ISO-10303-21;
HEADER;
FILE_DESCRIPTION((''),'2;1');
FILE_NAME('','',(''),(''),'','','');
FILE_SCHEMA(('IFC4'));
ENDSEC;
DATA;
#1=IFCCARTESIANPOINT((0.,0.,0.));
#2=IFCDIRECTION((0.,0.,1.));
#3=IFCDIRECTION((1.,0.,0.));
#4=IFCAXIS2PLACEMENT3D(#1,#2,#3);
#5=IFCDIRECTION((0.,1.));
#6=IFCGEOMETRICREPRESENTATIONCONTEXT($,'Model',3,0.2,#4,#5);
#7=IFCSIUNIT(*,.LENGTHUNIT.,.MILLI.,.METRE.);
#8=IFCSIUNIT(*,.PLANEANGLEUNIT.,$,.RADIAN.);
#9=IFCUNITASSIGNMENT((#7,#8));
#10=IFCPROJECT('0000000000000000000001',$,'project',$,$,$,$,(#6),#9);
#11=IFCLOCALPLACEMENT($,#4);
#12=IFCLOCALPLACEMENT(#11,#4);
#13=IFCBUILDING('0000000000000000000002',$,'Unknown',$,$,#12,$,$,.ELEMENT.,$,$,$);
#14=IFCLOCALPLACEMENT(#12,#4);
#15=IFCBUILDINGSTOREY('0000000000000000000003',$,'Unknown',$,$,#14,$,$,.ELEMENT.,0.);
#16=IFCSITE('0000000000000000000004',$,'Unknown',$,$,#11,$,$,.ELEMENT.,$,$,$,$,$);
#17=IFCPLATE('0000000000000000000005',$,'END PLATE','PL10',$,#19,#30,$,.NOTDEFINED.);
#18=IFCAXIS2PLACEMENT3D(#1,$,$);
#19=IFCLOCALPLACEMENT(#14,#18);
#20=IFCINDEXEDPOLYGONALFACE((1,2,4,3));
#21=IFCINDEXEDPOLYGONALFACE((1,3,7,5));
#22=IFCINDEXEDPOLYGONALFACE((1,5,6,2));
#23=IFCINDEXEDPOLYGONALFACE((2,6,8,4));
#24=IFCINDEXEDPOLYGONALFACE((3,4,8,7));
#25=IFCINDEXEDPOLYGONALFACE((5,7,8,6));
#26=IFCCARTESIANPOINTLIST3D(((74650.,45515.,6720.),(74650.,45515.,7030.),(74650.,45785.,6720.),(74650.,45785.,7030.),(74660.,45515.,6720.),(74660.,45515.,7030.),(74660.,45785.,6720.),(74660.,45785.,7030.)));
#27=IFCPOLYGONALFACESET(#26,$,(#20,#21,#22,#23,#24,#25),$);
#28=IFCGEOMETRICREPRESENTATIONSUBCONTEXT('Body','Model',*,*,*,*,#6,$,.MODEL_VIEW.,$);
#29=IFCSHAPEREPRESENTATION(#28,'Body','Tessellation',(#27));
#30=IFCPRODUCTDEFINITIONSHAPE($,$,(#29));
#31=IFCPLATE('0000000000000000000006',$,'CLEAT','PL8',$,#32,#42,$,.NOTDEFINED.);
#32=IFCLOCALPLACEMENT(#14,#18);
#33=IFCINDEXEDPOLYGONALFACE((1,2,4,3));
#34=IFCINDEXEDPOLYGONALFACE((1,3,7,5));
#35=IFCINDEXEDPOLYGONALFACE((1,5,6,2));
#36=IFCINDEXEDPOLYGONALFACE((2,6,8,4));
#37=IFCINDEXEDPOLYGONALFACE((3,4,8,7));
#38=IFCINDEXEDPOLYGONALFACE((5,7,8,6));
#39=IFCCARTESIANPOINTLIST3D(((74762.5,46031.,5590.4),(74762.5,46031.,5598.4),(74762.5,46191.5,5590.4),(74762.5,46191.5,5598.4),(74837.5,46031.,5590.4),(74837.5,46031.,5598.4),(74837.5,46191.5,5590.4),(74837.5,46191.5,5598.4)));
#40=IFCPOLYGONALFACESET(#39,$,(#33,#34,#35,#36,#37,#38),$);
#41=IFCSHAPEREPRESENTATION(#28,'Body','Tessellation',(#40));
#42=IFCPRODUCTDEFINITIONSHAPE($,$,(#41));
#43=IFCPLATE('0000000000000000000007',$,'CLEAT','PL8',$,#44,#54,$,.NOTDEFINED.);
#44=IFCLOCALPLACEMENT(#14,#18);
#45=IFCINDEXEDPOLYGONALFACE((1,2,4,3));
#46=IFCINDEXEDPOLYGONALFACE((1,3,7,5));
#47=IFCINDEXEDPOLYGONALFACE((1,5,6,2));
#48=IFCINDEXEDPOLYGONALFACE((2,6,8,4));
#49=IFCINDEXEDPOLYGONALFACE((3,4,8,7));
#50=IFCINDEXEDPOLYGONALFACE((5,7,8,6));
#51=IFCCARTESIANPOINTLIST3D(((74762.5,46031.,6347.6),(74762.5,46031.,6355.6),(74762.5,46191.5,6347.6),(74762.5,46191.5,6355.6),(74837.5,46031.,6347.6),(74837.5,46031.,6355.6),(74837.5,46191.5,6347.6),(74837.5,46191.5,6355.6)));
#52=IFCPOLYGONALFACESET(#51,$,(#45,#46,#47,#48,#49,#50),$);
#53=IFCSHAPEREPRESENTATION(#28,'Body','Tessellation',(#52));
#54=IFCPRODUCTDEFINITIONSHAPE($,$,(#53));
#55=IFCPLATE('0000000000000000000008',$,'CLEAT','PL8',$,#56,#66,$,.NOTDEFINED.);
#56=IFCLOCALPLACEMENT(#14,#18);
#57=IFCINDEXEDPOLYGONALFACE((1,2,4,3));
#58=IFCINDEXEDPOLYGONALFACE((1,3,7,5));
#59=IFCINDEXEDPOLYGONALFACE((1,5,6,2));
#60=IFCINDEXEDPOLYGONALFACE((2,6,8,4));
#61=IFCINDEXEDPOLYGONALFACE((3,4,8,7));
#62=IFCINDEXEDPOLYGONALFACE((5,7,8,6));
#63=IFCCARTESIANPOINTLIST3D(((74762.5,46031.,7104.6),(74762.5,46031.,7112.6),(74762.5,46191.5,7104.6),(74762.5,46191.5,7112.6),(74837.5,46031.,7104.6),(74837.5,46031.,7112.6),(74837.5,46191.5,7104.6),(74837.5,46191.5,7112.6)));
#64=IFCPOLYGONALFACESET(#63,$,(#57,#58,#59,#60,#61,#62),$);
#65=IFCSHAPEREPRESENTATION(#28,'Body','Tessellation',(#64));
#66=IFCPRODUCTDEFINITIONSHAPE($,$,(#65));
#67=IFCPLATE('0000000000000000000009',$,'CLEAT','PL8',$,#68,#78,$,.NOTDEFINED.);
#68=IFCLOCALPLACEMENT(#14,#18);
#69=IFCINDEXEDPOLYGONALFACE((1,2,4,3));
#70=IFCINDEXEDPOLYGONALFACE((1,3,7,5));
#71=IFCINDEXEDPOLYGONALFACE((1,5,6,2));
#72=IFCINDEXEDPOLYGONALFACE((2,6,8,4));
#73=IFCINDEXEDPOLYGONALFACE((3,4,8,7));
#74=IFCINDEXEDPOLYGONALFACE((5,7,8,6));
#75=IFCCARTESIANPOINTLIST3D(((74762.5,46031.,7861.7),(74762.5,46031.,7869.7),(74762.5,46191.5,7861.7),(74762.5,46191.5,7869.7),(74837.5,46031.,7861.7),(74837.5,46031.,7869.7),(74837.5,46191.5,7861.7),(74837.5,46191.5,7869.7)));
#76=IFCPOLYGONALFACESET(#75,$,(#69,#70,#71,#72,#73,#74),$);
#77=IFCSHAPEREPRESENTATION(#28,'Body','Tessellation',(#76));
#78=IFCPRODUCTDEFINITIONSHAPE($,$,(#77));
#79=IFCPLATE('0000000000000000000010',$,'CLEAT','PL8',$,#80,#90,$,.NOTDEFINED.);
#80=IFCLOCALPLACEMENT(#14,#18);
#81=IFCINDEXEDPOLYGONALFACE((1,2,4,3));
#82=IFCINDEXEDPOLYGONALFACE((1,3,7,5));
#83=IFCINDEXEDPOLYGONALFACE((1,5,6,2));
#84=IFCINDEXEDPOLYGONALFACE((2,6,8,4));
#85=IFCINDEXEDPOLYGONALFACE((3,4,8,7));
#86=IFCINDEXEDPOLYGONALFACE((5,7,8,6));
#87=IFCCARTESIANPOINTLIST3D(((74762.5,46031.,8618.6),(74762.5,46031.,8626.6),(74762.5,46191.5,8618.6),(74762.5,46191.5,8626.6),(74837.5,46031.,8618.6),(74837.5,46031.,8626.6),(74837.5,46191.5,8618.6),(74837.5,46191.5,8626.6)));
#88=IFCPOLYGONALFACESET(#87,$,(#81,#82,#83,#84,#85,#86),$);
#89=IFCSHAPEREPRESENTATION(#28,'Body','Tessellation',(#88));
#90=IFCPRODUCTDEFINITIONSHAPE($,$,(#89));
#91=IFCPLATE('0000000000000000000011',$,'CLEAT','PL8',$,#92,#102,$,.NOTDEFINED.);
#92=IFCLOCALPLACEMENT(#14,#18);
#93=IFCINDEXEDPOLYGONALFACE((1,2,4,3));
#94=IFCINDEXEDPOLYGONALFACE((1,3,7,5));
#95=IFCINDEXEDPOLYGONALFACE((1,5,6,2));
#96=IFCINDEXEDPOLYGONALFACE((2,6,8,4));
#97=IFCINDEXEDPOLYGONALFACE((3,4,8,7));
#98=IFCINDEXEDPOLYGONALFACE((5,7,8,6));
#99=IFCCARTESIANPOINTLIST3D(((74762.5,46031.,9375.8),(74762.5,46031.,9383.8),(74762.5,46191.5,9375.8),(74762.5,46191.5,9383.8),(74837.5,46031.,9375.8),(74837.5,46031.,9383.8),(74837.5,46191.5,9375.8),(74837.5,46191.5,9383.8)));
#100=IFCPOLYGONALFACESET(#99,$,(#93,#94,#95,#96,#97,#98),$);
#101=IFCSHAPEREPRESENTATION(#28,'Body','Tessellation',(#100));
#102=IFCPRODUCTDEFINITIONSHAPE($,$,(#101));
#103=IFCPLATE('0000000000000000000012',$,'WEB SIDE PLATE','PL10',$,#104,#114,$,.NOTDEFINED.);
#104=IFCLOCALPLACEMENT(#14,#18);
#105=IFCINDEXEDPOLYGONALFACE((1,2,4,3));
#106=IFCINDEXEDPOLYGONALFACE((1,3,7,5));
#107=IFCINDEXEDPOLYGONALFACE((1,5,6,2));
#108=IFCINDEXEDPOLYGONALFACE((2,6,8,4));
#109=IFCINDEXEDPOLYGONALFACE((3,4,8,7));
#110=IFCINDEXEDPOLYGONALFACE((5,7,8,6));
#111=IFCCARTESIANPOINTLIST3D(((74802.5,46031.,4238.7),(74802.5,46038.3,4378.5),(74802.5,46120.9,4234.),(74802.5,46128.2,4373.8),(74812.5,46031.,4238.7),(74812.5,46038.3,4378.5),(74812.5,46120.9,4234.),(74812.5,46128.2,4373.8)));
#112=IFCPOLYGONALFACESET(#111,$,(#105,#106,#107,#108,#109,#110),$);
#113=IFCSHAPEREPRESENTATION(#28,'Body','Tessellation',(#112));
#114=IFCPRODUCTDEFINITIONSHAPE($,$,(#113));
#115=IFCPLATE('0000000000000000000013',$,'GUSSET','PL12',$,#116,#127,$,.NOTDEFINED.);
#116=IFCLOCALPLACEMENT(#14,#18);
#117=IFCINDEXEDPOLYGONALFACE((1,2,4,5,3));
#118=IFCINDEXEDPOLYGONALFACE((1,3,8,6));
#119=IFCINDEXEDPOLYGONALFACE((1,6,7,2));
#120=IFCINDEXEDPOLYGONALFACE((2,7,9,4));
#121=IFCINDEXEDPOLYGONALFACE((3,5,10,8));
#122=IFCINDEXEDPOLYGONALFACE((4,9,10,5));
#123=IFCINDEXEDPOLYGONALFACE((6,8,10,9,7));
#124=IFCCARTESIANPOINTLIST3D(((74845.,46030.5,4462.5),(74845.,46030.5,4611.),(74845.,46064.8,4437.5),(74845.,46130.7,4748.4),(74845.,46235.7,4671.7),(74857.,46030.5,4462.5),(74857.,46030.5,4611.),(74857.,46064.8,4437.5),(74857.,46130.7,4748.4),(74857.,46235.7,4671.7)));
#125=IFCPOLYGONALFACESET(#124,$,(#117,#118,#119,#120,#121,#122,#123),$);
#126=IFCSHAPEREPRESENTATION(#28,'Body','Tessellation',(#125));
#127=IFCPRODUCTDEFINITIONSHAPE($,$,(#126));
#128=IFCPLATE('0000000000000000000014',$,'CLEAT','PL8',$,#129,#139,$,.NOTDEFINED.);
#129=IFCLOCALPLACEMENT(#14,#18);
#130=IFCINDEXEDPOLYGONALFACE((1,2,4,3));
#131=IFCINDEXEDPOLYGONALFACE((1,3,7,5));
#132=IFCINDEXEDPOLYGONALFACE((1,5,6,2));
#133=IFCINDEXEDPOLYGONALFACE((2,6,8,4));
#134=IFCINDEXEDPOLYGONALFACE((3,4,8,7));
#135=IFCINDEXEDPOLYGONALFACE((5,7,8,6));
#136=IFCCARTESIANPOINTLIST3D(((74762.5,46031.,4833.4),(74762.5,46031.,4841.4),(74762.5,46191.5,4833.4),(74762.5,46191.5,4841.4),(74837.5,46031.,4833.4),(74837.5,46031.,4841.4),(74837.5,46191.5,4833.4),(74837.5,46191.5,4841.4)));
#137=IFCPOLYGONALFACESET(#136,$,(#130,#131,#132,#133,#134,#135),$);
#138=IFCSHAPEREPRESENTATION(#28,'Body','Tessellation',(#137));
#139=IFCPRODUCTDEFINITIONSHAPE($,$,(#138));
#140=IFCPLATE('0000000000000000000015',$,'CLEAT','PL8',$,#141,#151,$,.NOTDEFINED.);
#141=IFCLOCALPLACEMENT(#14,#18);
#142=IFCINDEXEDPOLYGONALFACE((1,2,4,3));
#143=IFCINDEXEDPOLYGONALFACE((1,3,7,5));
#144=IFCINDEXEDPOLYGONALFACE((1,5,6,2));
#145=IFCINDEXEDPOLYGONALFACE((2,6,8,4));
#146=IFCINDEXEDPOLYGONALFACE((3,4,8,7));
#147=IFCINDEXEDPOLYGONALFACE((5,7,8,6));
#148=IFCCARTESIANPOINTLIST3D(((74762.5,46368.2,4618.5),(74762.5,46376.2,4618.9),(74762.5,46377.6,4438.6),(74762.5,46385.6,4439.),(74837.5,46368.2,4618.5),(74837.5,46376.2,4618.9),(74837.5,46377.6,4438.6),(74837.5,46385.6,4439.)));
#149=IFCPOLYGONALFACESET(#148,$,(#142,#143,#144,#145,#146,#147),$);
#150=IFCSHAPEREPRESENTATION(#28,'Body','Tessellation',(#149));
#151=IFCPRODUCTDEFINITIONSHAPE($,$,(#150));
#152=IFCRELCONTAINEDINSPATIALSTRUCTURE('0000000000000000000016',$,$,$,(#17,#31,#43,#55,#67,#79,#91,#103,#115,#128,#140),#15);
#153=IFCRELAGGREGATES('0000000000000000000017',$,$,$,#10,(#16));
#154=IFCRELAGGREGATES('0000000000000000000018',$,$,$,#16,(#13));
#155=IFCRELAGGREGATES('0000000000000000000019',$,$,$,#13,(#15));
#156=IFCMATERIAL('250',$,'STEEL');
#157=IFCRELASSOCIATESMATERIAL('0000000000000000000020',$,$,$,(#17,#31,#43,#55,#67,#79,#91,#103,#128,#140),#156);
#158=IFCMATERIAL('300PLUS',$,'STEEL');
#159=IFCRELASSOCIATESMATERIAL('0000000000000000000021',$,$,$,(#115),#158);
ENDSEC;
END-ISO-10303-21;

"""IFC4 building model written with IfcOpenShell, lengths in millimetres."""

from ifc_helpers import new_model, si_unit, direction, frame, origin_with_axes, place, context, subcontext, project, spatial, line, indexed_curve, outline, extrude, material, element, save


model = new_model("IFC4")

# Units and contexts
model_context = context("Model", 3, precision=0.2, world=origin_with_axes(), true_north=direction((0.0, 1.0)))
body_context = subcontext(model_context, "Body", "Model", "MODEL_VIEW")
ifc_project = project(units=[si_unit("LENGTHUNIT", "METRE", prefix="MILLI"), si_unit("PLANEANGLEUNIT", "RADIAN")], contexts=[model_context])

# Site, building, storey
site_placement = place(None, origin_with_axes())
site = spatial("IfcSite", under=ifc_project, at=site_placement, Name="Unknown", CompositionType="ELEMENT")
building_placement = place(site_placement, origin_with_axes())
building = spatial("IfcBuilding", under=site, at=building_placement, Name="Unknown", CompositionType="ELEMENT")
storey_placement = place(building_placement, origin_with_axes())
storey = spatial("IfcBuildingStorey", under=building, at=storey_placement, Name="Unknown", CompositionType="ELEMENT", Elevation=0.0)

# Shared definitions
ifc_material_1 = material(Name="300PLUS", Category="STEEL")

# Plates
ifc_material_2 = material(Name="250", Category="STEEL")
plate_1_placement = place(storey_placement, frame((74655.0, 45785.0, 6720.0), z_axis=(-1.0, 0.0, 0.0), x_axis=(0.0, -1.0, 0.0)))
element("IfcPlate", 1, at=plate_1_placement, inside=storey, material=ifc_material_2, Name="END PLATE", Description="PL10", PredefinedType="NOTDEFINED", context=body_context, shape_type="SolidModel", body=[
    extrude(outline(indexed_curve([(0.0, 0.0), (270.0, 0.0), (270.0, 310.0), (0.0, 310.0)], segments=[line(1, 2, 3, 4, 1)])), frame((0.0, 0.0, 5.0), z_axis=(0.0, 0.0, 1.0), x_axis=(1.0, 0.0, 0.0)), (0.0, 0.0, -1.0), 10.0),
])
for number, where, z_axis, x_axis, name in (
    (2, (74762.5, 46031.0, 5594.4), (0.0, 0.0, 1.0), (1.0, 0.0, 0.0), "CLEAT"),
    (3, (74762.5, 46031.0, 6351.6), (0.0, 0.0, 1.0), (1.0, 0.0, 0.0), "CLEAT"),
    (4, (74762.5, 46031.0, 7108.6), (0.0, 0.0, 1.0), (1.0, 0.0, 0.0), "CLEAT"),
    (5, (74762.5, 46031.0, 7865.7), (0.0, 0.0, 1.0), (1.0, 0.0, 0.0), "CLEAT"),
    (6, (74762.5, 46031.0, 8622.6), (0.0, 0.0, 1.0), (1.0, 0.0, 0.0), "CLEAT"),
    (7, (74762.5, 46031.0, 9379.8), (0.0, 0.0, 1.0), (1.0, 0.0, 0.0), "CLEAT"),
):
    element("IfcPlate", number, at=place(storey_placement, frame(where, z_axis=z_axis, x_axis=x_axis)), inside=storey, material=ifc_material_2, Name=name, Description="PL8", PredefinedType="NOTDEFINED", context=body_context, shape_type="SolidModel", body=[
        extrude(outline(indexed_curve([(0.0, 0.0), (75.0, 0.0), (75.0, 160.5), (0.0, 160.5)], segments=[line(1, 2, 3, 4, 1)])), frame((0.0, 0.0, 4.0), z_axis=(0.0, 0.0, 1.0), x_axis=(1.0, 0.0, 0.0)), (0.0, 0.0, -1.0), 8.0),
    ])
plate_2_placement = place(storey_placement, frame((74807.5, 46128.2, 4373.8), z_axis=(1.0, 0.0, 0.0), x_axis=(0.0, -0.998636, 0.052209)))
element("IfcPlate", 8, at=plate_2_placement, inside=storey, material=ifc_material_2, Name="WEB SIDE PLATE", Description="PL10", PredefinedType="NOTDEFINED", context=body_context, shape_type="SolidModel", body=[
    extrude(outline(indexed_curve([(0.0, 0.0), (90.0, 0.0), (90.0, 140.0), (0.0, 140.0)], segments=[line(1, 2, 3, 4, 1)])), frame((0.0, 0.0, 5.0), z_axis=(0.0, 0.0, 1.0), x_axis=(1.0, 0.0, 0.0)), (0.0, 0.0, -1.0), 10.0),
])
plate_3_placement = place(storey_placement, frame((74851.0, 46030.5, 4462.5), z_axis=(1.0, 0.0, 0.0), x_axis=(0.0, 0.808124, -0.589012)))
element("IfcPlate", 9, at=plate_3_placement, inside=storey, material=ifc_material_1, Name="GUSSET", Description="PL12", PredefinedType="NOTDEFINED", context=body_context, shape_type="SolidModel", body=[
    extrude(outline(indexed_curve([(0.0, 0.0), (42.4, 0.0), (42.6, 289.9), (-87.4, 290.1), (-87.5, 120.0)], segments=[line(1, 2, 3, 4, 5, 1)])), frame((0.0, 0.0, 6.0), z_axis=(0.0, 0.0, 1.0), x_axis=(1.0, 0.0, 0.0)), (0.0, 0.0, -1.0), 12.0),
])
plate_4_placement = place(storey_placement, frame((74762.5, 46031.0, 4837.4), z_axis=(0.0, 0.0, 1.0), x_axis=(1.0, 0.0, 0.0)))
element("IfcPlate", 10, at=plate_4_placement, inside=storey, material=ifc_material_2, Name="CLEAT", Description="PL8", PredefinedType="NOTDEFINED", context=body_context, shape_type="SolidModel", body=[
    extrude(outline(indexed_curve([(0.0, 0.0), (75.0, 0.0), (75.0, 160.5), (0.0, 160.5)], segments=[line(1, 2, 3, 4, 1)])), frame((0.0, 0.0, 4.0), z_axis=(0.0, 0.0, 1.0), x_axis=(1.0, 0.0, 0.0)), (0.0, 0.0, -1.0), 8.0),
])
plate_5_placement = place(storey_placement, frame((74762.5, 46372.2, 4618.7), z_axis=(0.0, 0.998638, 0.05218), x_axis=(1.0, 0.0, 0.0)))
element("IfcPlate", 11, at=plate_5_placement, inside=storey, material=ifc_material_2, Name="CLEAT", Description="PL8", PredefinedType="NOTDEFINED", context=body_context, shape_type="SolidModel", body=[
    extrude(outline(indexed_curve([(0.0, 0.0), (75.0, 0.0), (75.0, 180.1), (0.0, 180.1)], segments=[line(1, 2, 3, 4, 1)])), frame((0.0, 0.0, 4.0), z_axis=(0.0, 0.0, 1.0), x_axis=(1.0, 0.0, 0.0)), (0.0, 0.0, -1.0), 8.0),
])

save(model, "model.ifc")
